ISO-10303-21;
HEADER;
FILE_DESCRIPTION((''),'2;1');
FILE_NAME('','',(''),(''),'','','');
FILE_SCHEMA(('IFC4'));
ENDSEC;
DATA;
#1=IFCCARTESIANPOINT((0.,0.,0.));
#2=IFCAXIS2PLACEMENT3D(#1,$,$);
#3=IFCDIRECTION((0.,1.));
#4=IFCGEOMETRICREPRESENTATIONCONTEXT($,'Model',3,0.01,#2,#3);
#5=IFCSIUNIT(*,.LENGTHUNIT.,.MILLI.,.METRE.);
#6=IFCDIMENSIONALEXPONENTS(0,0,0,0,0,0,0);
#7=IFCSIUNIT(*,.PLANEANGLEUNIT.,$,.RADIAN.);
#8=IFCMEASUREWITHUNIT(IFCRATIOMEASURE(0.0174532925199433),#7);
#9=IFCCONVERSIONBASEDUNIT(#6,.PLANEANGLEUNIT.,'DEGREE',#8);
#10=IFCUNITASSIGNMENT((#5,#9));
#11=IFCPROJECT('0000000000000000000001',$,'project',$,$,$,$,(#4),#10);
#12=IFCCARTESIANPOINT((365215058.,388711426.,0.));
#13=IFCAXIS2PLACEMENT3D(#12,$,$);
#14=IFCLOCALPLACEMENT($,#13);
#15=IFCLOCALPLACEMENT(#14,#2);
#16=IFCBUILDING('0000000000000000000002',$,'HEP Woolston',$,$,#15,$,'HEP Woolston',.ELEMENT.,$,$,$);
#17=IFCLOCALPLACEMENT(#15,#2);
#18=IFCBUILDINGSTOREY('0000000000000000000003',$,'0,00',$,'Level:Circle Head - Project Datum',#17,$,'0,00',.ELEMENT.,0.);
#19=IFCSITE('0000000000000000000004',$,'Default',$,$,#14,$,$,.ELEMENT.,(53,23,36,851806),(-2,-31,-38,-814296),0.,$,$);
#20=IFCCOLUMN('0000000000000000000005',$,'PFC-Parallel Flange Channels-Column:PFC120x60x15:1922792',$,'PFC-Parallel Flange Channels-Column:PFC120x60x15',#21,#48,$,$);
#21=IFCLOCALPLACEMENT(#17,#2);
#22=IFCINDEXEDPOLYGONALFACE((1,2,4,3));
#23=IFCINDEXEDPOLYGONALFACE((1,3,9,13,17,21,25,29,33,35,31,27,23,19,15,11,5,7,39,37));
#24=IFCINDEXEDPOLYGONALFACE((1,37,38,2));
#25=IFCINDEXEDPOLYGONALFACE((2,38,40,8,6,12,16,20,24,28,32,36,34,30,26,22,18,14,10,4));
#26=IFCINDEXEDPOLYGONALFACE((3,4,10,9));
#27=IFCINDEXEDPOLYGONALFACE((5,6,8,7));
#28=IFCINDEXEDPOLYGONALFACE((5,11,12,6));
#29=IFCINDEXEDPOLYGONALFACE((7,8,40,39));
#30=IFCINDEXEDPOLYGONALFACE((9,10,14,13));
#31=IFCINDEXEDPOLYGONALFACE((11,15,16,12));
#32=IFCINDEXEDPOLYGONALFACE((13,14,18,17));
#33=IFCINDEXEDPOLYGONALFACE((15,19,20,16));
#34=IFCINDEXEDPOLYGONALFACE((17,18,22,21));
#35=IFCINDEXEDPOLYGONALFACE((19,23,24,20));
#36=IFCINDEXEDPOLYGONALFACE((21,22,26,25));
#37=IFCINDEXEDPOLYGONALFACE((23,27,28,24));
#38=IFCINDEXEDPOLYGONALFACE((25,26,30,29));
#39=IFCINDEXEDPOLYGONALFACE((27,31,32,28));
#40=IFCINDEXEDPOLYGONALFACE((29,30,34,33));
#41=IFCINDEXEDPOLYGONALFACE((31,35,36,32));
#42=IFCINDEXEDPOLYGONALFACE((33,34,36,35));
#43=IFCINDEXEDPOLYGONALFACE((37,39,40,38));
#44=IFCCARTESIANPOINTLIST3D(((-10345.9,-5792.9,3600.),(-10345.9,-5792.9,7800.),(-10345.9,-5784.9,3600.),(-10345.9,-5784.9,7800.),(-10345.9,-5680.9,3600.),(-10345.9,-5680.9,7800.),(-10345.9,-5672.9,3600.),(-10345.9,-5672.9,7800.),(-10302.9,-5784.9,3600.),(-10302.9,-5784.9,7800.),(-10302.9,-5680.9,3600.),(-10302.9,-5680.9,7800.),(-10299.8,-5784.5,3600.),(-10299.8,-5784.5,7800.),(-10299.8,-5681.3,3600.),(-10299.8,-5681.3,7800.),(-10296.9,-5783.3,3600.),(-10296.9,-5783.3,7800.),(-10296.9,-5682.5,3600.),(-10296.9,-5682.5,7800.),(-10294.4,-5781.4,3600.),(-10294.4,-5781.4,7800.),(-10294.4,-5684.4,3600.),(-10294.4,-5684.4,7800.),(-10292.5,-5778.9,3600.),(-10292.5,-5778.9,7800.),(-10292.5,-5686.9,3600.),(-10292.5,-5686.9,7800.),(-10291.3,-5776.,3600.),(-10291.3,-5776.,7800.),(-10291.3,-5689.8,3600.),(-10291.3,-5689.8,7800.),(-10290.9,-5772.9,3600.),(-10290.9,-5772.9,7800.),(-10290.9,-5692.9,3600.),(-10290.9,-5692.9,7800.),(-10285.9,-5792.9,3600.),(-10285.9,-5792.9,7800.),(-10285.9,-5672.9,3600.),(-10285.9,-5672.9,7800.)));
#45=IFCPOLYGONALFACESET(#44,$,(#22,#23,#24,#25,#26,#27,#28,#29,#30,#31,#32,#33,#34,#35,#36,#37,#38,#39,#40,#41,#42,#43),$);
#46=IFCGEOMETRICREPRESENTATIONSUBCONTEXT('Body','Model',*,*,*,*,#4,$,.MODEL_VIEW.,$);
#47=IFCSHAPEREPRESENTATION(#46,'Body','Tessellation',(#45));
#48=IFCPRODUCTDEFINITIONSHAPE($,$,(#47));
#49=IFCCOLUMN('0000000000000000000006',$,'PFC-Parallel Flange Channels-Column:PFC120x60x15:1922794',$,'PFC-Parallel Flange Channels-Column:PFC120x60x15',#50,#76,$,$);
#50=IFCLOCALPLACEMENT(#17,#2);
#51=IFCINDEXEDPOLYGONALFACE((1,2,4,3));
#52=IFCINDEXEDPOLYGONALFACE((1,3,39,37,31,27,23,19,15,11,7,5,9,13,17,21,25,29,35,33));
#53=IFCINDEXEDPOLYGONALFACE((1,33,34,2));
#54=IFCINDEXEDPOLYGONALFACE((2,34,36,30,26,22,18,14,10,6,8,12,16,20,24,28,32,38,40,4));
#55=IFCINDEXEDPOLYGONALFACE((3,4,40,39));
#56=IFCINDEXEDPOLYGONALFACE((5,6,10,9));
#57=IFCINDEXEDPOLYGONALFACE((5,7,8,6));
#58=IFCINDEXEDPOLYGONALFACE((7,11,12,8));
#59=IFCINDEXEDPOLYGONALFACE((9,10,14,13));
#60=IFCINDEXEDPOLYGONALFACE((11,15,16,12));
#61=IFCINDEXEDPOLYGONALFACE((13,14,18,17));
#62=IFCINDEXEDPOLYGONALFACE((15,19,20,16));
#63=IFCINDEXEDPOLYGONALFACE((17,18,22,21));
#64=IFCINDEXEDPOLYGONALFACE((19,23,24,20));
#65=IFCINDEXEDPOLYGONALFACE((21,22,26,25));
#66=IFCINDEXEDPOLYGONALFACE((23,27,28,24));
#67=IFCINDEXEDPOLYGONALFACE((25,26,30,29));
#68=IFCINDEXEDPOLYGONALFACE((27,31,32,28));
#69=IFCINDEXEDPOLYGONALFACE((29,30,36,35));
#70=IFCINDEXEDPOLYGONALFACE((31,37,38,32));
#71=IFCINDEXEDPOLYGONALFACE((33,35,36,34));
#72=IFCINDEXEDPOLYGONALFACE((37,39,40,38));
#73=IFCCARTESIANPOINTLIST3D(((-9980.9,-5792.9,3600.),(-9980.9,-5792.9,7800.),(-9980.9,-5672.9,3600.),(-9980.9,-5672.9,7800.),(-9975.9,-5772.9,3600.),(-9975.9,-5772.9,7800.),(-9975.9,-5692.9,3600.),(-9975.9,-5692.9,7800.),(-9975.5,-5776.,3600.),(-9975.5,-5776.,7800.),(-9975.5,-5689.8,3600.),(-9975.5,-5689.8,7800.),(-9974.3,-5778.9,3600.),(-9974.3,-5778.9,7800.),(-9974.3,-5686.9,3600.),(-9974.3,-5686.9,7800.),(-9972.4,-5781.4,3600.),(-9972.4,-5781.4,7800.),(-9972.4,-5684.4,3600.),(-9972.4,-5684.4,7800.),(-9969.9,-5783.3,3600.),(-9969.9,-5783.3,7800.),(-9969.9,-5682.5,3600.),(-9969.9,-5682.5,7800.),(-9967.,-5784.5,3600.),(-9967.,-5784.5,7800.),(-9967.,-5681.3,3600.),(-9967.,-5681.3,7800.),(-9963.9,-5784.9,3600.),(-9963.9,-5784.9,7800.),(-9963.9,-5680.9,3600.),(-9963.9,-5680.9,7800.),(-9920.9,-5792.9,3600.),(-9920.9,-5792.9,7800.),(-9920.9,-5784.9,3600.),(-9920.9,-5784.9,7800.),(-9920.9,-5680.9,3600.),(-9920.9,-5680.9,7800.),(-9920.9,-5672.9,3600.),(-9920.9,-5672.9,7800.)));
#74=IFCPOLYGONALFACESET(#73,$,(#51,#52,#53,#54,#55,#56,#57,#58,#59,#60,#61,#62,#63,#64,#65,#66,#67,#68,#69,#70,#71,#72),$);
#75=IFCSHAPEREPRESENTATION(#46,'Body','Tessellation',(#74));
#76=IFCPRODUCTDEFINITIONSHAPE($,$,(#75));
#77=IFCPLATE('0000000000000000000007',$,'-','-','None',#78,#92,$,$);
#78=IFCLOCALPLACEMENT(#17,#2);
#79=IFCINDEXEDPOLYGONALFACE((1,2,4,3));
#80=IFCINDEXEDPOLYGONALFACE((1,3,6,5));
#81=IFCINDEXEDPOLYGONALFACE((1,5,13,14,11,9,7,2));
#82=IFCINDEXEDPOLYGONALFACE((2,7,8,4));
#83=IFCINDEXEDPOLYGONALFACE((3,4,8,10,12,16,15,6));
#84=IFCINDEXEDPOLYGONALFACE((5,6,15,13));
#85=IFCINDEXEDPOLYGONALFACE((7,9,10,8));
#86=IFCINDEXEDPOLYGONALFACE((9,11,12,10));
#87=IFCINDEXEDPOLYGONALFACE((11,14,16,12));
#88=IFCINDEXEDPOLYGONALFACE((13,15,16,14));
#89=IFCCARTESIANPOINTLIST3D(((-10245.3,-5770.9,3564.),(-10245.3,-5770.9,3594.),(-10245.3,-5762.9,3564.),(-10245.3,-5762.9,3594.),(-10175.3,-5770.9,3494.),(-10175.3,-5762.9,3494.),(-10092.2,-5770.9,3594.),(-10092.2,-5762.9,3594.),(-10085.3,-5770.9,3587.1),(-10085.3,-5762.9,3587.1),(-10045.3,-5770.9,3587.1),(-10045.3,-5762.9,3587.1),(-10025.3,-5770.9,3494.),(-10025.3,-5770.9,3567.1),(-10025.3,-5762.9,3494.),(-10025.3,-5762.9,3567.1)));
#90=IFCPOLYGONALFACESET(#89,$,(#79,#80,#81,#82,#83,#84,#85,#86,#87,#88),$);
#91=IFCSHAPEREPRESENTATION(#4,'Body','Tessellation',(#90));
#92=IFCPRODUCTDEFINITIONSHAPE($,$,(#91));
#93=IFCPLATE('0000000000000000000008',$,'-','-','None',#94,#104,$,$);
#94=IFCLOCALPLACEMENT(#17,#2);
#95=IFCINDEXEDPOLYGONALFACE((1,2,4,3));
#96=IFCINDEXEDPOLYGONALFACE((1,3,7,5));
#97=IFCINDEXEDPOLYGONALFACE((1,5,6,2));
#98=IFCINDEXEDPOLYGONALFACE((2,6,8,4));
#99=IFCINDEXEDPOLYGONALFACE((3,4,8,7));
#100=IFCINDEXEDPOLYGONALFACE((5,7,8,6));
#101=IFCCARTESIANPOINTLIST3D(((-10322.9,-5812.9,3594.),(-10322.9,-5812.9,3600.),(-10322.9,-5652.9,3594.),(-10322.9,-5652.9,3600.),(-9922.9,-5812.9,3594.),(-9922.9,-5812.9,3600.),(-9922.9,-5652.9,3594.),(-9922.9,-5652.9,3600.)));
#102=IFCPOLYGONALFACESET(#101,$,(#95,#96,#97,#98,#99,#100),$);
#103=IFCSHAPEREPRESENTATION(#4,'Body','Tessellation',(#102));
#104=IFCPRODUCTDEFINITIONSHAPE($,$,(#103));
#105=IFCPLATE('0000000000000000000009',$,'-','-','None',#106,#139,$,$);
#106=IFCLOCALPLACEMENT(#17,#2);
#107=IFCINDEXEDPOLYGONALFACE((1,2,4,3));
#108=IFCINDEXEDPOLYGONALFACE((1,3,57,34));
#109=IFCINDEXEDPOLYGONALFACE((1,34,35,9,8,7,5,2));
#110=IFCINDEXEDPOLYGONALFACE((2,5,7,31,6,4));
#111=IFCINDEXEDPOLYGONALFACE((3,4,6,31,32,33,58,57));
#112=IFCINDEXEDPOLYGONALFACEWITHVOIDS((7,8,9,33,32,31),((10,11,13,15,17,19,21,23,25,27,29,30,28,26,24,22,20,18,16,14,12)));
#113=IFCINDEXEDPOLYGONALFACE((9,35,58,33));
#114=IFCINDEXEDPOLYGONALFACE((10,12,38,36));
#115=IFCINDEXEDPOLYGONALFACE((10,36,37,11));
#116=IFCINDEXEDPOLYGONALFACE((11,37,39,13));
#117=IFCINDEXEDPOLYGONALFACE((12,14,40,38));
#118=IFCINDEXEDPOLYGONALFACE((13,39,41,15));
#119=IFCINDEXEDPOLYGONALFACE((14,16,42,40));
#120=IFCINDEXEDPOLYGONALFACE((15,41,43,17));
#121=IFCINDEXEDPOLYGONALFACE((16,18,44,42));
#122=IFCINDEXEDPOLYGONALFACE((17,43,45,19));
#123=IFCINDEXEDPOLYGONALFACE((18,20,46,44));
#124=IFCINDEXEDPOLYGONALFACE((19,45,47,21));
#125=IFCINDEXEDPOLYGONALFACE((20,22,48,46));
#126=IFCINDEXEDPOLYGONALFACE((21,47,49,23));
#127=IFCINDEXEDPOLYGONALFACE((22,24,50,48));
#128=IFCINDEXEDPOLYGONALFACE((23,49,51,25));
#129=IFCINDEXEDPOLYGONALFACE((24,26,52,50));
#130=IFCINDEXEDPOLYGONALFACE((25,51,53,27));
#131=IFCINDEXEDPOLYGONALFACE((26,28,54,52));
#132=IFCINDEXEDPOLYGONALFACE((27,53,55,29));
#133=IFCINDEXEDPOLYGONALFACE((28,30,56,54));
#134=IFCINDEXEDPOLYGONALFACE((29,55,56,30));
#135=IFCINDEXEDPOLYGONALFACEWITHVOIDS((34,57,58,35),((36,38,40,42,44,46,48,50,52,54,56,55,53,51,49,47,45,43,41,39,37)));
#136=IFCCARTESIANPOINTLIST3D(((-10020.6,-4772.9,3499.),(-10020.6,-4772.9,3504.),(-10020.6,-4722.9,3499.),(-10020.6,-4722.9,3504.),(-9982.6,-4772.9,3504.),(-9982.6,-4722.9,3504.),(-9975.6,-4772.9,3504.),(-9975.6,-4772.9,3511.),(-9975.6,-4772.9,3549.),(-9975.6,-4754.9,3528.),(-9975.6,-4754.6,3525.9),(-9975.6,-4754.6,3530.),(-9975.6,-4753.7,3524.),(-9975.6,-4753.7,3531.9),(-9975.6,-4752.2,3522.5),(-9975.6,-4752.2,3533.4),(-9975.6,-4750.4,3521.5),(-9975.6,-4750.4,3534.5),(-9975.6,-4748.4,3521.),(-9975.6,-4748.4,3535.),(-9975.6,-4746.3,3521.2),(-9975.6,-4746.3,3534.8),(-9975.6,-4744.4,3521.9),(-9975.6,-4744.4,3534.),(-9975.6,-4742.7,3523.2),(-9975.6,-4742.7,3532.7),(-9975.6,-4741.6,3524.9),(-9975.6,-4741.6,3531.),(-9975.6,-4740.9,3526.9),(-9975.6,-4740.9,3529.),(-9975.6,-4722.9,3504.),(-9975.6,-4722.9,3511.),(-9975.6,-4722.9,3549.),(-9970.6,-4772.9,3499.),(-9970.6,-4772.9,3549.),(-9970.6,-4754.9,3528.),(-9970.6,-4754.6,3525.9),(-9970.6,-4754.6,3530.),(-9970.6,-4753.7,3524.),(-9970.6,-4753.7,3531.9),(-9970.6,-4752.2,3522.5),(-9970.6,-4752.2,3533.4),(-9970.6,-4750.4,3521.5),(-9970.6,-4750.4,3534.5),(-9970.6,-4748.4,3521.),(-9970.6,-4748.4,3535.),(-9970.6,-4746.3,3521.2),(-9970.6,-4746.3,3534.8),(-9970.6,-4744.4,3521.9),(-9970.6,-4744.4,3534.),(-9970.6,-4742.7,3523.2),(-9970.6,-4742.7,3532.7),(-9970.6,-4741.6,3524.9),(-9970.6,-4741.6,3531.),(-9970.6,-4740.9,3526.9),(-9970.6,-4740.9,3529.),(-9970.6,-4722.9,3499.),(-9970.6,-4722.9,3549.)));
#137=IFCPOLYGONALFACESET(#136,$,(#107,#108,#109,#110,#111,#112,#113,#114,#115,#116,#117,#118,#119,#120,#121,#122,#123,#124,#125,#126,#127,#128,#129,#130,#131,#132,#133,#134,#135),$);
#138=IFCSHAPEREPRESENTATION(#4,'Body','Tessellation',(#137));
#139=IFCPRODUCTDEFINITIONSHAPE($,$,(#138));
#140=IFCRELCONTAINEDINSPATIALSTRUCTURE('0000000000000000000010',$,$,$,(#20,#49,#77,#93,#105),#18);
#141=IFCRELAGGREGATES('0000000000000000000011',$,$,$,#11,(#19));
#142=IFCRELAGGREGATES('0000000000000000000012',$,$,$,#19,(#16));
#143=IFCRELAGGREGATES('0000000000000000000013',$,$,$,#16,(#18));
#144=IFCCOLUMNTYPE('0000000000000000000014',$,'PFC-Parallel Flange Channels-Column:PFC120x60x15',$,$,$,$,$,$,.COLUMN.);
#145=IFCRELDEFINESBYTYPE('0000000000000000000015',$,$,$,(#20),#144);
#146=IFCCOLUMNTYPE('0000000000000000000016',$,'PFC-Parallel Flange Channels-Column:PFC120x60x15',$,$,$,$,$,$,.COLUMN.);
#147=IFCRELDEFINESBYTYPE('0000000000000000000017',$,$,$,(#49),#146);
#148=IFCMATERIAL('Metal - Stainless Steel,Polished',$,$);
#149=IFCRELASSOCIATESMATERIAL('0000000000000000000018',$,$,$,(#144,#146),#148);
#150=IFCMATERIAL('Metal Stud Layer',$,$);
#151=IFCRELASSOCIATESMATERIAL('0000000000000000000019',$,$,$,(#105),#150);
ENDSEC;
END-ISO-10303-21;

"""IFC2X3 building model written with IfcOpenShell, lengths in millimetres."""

from ifc_helpers import new_model, entity, si_unit, converted_unit, point, direction, frame, frame_2d, origin, origin_with_axes, origin_2d_with_axis, place, context, subcontext, project, spatial, polyline, circle_curve, line_curve, parameter, trimmed, segment, composite_curve, circle, outline, extrude, source, transform, mapped, material, type_object, type_shapes, element, save


model = new_model("IFC2X3")

# Units and contexts
model_context = context("Model", 3, precision=0.01, world=origin(), true_north=direction((0.0, 1.0)))
body_context = subcontext(model_context, "Body", "Model", "MODEL_VIEW")
ifc_project = project(units=[si_unit("LENGTHUNIT", "METRE", prefix="MILLI"), converted_unit("PLANEANGLEUNIT", "DEGREE", entity("IfcRatioMeasure", 0.0174532925199433), si_unit("PLANEANGLEUNIT", "RADIAN"), dimensions=[0, 0, 0, 0, 0, 0, 0])], contexts=[model_context])

# Site, building, storey
site_placement = place(None, frame((365215058.0, 388711426.0, 0.0)))
site = spatial("IfcSite", under=ifc_project, at=site_placement, Name="Default", CompositionType="ELEMENT", RefLatitude=(53, 23, 36, 851806), RefLongitude=(-2, -31, -38, -814296), RefElevation=0.0)
building_placement = place(site_placement, origin())
building = spatial("IfcBuilding", under=site, at=building_placement, Name="HEP Woolston", LongName="HEP Woolston", CompositionType="ELEMENT")
storey_placement = place(building_placement, origin())
storey = spatial("IfcBuildingStorey", under=building, at=storey_placement, Name="0,00", ObjectType="Level:Circle Head - Project Datum", LongName="0,00", CompositionType="ELEMENT", Elevation=0.0)

# Columns
ifc_material_1 = material(Name="Metal - Stainless Steel,Polished")
column_type_1 = type_object("IfcColumnType", Name="PFC-Parallel Flange Channels-Column:PFC120x60x15", PredefinedType="COLUMN", material=ifc_material_1)
shared_shape_1 = source(origin(), body_context, "Body", "SweptSolid", [
    extrude(outline(composite_curve([segment(polyline([(-60.0, -28.4), (60.0, -28.4)]), True, "CONTINUOUS"), segment(polyline([(60.0, -28.4), (60.0, 31.6)]), True, "CONTINUOUS"), segment(polyline([(60.0, 31.6), (52.0, 31.6)]), True, "CONTINUOUS"), segment(polyline([(52.0, 31.6), (52.0, -11.4)]), True, "CONTINUOUS"), segment(trimmed(circle_curve(frame_2d((40.0, -11.4), x_axis=(1.0, 0.0)), 12.0), [parameter(270.0)], [parameter(0.0)], True, "PARAMETER"), False, "CONTINUOUS"), segment(polyline([(40.0, -23.4), (-40.0, -23.4)]), True, "CONTINUOUS"), segment(trimmed(circle_curve(frame_2d((-40.0, -11.4), x_axis=(0.0, -1.0)), 12.0), [parameter(270.0)], [parameter(0.0)], True, "PARAMETER"), False, "CONTINUOUS"), segment(polyline([(-52.0, -11.4), (-52.0, 31.6)]), True, "CONTINUOUS"), segment(polyline([(-52.0, 31.6), (-60.0, 31.6)]), True, "CONTINUOUS"), segment(polyline([(-60.0, 31.6), (-60.0, -28.4)]), True, "CONTINUOUS")], self_intersect=False)), frame((5.4, 0.0, 3600.0), z_axis=(0.0, 0.0, 1.0), x_axis=(0.0, -1.0, 0.0)), (0.0, 0.0, 1.0), 4200.0),
])
type_shapes(column_type_1, [shared_shape_1])
column_1_placement = place(storey_placement, frame((-10308.9, -5732.9, 0.0), z_axis=(0.0, 0.0, 1.0), x_axis=(-1.0, 0.0, 0.0)))
element("IfcColumn", 1, at=column_1_placement, inside=storey, type_object=column_type_1, Name="PFC-Parallel Flange Channels-Column:PFC120x60x15:1922792", ObjectType="PFC-Parallel Flange Channels-Column:PFC120x60x15", context=body_context, shape_type="MappedRepresentation", body=[
    mapped(shared_shape_1, transform((0.0, 0.0, 0.0), scale=1.0)),
])
column_type_2 = type_object("IfcColumnType", Name="PFC-Parallel Flange Channels-Column:PFC120x60x15", PredefinedType="COLUMN", material=ifc_material_1)
shared_shape_2 = source(origin(), body_context, "Body", "SweptSolid", [
    extrude(outline(composite_curve([segment(polyline([(-60.0, -28.4), (60.0, -28.4)]), True, "CONTINUOUS"), segment(polyline([(60.0, -28.4), (60.0, 31.6)]), True, "CONTINUOUS"), segment(polyline([(60.0, 31.6), (52.0, 31.6)]), True, "CONTINUOUS"), segment(polyline([(52.0, 31.6), (52.0, -11.4)]), True, "CONTINUOUS"), segment(trimmed(circle_curve(frame_2d((40.0, -11.4), x_axis=(1.0, 0.0)), 12.0), [parameter(270.0)], [parameter(0.0)], True, "PARAMETER"), False, "CONTINUOUS"), segment(polyline([(40.0, -23.4), (-40.0, -23.4)]), True, "CONTINUOUS"), segment(trimmed(circle_curve(frame_2d((-40.0, -11.4), x_axis=(0.0, -1.0)), 12.0), [parameter(270.0)], [parameter(0.0)], True, "PARAMETER"), False, "CONTINUOUS"), segment(polyline([(-52.0, -11.4), (-52.0, 31.6)]), True, "CONTINUOUS"), segment(polyline([(-52.0, 31.6), (-60.0, 31.6)]), True, "CONTINUOUS"), segment(polyline([(-60.0, 31.6), (-60.0, -28.4)]), True, "CONTINUOUS")], self_intersect=False)), frame((5.4, 0.0, 3600.0), z_axis=(0.0, 0.0, 1.0), x_axis=(0.0, -1.0, 0.0)), (0.0, 0.0, 1.0), 4200.0),
])
type_shapes(column_type_2, [shared_shape_2])
column_2_placement = place(storey_placement, frame((-9957.9, -5732.9, 0.0)))
element("IfcColumn", 2, at=column_2_placement, inside=storey, type_object=column_type_2, Name="PFC-Parallel Flange Channels-Column:PFC120x60x15:1922794", ObjectType="PFC-Parallel Flange Channels-Column:PFC120x60x15", context=body_context, shape_type="MappedRepresentation", body=[
    mapped(shared_shape_2, transform((0.0, 0.0, 0.0), scale=1.0)),
])

# Plates
plate_1_placement = place(storey_placement, frame((-10025.3, -5770.9, 3567.1), z_axis=(0.0, 1.0, 0.0), x_axis=(-1.0, 0.0, 0.0)))
element("IfcPlate", 3, at=plate_1_placement, inside=storey, Name="-", Description="-", ObjectType="None", context=model_context, shape_type="SweptSolid", body=[
    extrude(outline(polyline([(0.0, 0.0), (0.0, -73.1), (150.0, -73.1), (220.0, -3.1), (220.0, 26.9), (66.9, 26.9), (60.0, 20.0), (20.0, 20.0), (0.0, 0.0)])), origin_with_axes(), (0.0, 0.0, 1.0), 8.0),
])
plate_2_placement = place(storey_placement, frame((-10322.9, -5812.9, 3594.0)))
element("IfcPlate", 4, at=plate_2_placement, inside=storey, Name="-", Description="-", ObjectType="None", context=model_context, shape_type="SweptSolid", body=[
    extrude(outline(polyline([(0.0, 0.0), (400.0, 0.0), (400.0, 160.0), (0.0, 160.0), (0.0, 0.0)])), origin_with_axes(), (0.0, 0.0, 1.0), 6.0),
])

# Plate, openings
ifc_material_2 = material(Name="Metal Stud Layer")
plate_3_placement = place(storey_placement, frame((-9970.6, -4772.9, 3499.0), z_axis=(0.0, 1.0, 0.0), x_axis=(-1.0, 0.0, 0.0)))
plate_3 = element("IfcPlate", 5, at=plate_3_placement, inside=storey, material=ifc_material_2, Name="-", Description="-", ObjectType="None", context=model_context, shape_type="SweptSolid", body=[
    extrude(outline(polyline([(0.0, 0.0), (50.0, 0.0), (50.0, 5.0), (5.0, 5.0), (5.0, 50.0), (0.0, 50.0), (0.0, 0.0)])), origin_with_axes(), (0.0, 0.0, 1.0), 50.0),
])
opening_1_placement = place(plate_3_placement, frame((0.0, 0.0, 0.0), z_axis=(0.0, 0.0, 1.0), x_axis=(1.0, 0.0, 0.0)))
element("IfcOpeningElement", 6, at=opening_1_placement, cuts=plate_3, ObjectType="Opening", context=model_context, shape_type="SweptSolid", body=[
    extrude(outline(composite_curve([segment(trimmed(line_curve((50.0, 5.0), (1.0, 0.0), 3.532613), [point((50.0, 5.0))], [point((46.5, 5.0))], True, "CARTESIAN"), True, "CONTINUOUS"), segment(trimmed(circle_curve(frame_2d((46.5, 1.5), x_axis=(-1.0, 0.0)), 3.5), [point((46.5, 5.0))], [point((50.0, 1.5))], False, "CARTESIAN"), True, "CONTINUOUS"), segment(trimmed(line_curve((50.0, 1.5), (0.0, -1.0), 3.532613), [point((50.0, 1.5))], [point((50.0, 5.0))], True, "CARTESIAN"), True, "CONTINUOUS")], self_intersect="UNKNOWN")), origin(), (0.0, 0.0, 1.0), 50.0),
])
opening_2_placement = place(plate_3_placement, origin_with_axes())
element("IfcOpeningElement", 7, at=opening_2_placement, cuts=plate_3, ObjectType="Opening", context=model_context, shape_type="SweptSolid", body=[
    extrude(outline(composite_curve([segment(trimmed(line_curve((5.0, 5.0), (0.0, -1.0), 7.046301), [point((5.0, 5.0))], [point((5.0, 12.0))], False, "CARTESIAN"), True, "CONTINUOUS"), segment(trimmed(circle_curve(frame_2d((12.0, 12.0), x_axis=(1.0, 0.0)), 7.0), [point((5.0, 12.0))], [point((12.0, 5.0))], True, "CARTESIAN"), True, "CONTINUOUS"), segment(trimmed(line_curve((12.0, 5.0), (1.0, 0.0), 7.046301), [point((12.0, 5.0))], [point((5.0, 5.0))], False, "CARTESIAN"), True, "CONTINUOUS")], self_intersect="UNKNOWN")), origin(), (0.0, 0.0, 1.0), 50.0),
])
opening_3_placement = place(plate_3_placement, frame((0.0, 0.0, 0.0), z_axis=(0.0, 0.0, 1.0), x_axis=(1.0, 0.0, 0.0)))
element("IfcOpeningElement", 8, at=opening_3_placement, cuts=plate_3, ObjectType="Opening", context=model_context, shape_type="SweptSolid", body=[
    extrude(outline(composite_curve([segment(trimmed(line_curve((5.0, 50.0), (1.0, 0.0), 3.4874), [point((5.0, 50.0))], [point((1.5, 50.0))], True, "CARTESIAN"), True, "CONTINUOUS"), segment(trimmed(circle_curve(frame_2d((1.5, 46.5), x_axis=(-1.0, 0.0)), 3.5), [point((1.5, 50.0))], [point((5.0, 46.5))], False, "CARTESIAN"), True, "CONTINUOUS"), segment(trimmed(line_curve((5.0, 46.5), (0.0, -1.0), 3.4874), [point((5.0, 46.5))], [point((5.0, 50.0))], True, "CARTESIAN"), True, "CONTINUOUS")], self_intersect="UNKNOWN")), origin(), (0.0, 0.0, 1.0), 50.0),
])
opening_4_placement = place(plate_3_placement, frame((-0.5, 29.0, 25.0), z_axis=(1.0, 0.0, 0.0), x_axis=(0.0, 0.0, -1.0)))
element("IfcOpeningElement", 9, at=opening_4_placement, cuts=plate_3, ObjectType="Opening", context=model_context, shape_type="SweptSolid", body=[
    extrude(circle(Radius=7.0, at=origin_2d_with_axis()), origin(), (0.0, 0.0, 1.0), 6.0),
])

save(model, "model.ifc")
